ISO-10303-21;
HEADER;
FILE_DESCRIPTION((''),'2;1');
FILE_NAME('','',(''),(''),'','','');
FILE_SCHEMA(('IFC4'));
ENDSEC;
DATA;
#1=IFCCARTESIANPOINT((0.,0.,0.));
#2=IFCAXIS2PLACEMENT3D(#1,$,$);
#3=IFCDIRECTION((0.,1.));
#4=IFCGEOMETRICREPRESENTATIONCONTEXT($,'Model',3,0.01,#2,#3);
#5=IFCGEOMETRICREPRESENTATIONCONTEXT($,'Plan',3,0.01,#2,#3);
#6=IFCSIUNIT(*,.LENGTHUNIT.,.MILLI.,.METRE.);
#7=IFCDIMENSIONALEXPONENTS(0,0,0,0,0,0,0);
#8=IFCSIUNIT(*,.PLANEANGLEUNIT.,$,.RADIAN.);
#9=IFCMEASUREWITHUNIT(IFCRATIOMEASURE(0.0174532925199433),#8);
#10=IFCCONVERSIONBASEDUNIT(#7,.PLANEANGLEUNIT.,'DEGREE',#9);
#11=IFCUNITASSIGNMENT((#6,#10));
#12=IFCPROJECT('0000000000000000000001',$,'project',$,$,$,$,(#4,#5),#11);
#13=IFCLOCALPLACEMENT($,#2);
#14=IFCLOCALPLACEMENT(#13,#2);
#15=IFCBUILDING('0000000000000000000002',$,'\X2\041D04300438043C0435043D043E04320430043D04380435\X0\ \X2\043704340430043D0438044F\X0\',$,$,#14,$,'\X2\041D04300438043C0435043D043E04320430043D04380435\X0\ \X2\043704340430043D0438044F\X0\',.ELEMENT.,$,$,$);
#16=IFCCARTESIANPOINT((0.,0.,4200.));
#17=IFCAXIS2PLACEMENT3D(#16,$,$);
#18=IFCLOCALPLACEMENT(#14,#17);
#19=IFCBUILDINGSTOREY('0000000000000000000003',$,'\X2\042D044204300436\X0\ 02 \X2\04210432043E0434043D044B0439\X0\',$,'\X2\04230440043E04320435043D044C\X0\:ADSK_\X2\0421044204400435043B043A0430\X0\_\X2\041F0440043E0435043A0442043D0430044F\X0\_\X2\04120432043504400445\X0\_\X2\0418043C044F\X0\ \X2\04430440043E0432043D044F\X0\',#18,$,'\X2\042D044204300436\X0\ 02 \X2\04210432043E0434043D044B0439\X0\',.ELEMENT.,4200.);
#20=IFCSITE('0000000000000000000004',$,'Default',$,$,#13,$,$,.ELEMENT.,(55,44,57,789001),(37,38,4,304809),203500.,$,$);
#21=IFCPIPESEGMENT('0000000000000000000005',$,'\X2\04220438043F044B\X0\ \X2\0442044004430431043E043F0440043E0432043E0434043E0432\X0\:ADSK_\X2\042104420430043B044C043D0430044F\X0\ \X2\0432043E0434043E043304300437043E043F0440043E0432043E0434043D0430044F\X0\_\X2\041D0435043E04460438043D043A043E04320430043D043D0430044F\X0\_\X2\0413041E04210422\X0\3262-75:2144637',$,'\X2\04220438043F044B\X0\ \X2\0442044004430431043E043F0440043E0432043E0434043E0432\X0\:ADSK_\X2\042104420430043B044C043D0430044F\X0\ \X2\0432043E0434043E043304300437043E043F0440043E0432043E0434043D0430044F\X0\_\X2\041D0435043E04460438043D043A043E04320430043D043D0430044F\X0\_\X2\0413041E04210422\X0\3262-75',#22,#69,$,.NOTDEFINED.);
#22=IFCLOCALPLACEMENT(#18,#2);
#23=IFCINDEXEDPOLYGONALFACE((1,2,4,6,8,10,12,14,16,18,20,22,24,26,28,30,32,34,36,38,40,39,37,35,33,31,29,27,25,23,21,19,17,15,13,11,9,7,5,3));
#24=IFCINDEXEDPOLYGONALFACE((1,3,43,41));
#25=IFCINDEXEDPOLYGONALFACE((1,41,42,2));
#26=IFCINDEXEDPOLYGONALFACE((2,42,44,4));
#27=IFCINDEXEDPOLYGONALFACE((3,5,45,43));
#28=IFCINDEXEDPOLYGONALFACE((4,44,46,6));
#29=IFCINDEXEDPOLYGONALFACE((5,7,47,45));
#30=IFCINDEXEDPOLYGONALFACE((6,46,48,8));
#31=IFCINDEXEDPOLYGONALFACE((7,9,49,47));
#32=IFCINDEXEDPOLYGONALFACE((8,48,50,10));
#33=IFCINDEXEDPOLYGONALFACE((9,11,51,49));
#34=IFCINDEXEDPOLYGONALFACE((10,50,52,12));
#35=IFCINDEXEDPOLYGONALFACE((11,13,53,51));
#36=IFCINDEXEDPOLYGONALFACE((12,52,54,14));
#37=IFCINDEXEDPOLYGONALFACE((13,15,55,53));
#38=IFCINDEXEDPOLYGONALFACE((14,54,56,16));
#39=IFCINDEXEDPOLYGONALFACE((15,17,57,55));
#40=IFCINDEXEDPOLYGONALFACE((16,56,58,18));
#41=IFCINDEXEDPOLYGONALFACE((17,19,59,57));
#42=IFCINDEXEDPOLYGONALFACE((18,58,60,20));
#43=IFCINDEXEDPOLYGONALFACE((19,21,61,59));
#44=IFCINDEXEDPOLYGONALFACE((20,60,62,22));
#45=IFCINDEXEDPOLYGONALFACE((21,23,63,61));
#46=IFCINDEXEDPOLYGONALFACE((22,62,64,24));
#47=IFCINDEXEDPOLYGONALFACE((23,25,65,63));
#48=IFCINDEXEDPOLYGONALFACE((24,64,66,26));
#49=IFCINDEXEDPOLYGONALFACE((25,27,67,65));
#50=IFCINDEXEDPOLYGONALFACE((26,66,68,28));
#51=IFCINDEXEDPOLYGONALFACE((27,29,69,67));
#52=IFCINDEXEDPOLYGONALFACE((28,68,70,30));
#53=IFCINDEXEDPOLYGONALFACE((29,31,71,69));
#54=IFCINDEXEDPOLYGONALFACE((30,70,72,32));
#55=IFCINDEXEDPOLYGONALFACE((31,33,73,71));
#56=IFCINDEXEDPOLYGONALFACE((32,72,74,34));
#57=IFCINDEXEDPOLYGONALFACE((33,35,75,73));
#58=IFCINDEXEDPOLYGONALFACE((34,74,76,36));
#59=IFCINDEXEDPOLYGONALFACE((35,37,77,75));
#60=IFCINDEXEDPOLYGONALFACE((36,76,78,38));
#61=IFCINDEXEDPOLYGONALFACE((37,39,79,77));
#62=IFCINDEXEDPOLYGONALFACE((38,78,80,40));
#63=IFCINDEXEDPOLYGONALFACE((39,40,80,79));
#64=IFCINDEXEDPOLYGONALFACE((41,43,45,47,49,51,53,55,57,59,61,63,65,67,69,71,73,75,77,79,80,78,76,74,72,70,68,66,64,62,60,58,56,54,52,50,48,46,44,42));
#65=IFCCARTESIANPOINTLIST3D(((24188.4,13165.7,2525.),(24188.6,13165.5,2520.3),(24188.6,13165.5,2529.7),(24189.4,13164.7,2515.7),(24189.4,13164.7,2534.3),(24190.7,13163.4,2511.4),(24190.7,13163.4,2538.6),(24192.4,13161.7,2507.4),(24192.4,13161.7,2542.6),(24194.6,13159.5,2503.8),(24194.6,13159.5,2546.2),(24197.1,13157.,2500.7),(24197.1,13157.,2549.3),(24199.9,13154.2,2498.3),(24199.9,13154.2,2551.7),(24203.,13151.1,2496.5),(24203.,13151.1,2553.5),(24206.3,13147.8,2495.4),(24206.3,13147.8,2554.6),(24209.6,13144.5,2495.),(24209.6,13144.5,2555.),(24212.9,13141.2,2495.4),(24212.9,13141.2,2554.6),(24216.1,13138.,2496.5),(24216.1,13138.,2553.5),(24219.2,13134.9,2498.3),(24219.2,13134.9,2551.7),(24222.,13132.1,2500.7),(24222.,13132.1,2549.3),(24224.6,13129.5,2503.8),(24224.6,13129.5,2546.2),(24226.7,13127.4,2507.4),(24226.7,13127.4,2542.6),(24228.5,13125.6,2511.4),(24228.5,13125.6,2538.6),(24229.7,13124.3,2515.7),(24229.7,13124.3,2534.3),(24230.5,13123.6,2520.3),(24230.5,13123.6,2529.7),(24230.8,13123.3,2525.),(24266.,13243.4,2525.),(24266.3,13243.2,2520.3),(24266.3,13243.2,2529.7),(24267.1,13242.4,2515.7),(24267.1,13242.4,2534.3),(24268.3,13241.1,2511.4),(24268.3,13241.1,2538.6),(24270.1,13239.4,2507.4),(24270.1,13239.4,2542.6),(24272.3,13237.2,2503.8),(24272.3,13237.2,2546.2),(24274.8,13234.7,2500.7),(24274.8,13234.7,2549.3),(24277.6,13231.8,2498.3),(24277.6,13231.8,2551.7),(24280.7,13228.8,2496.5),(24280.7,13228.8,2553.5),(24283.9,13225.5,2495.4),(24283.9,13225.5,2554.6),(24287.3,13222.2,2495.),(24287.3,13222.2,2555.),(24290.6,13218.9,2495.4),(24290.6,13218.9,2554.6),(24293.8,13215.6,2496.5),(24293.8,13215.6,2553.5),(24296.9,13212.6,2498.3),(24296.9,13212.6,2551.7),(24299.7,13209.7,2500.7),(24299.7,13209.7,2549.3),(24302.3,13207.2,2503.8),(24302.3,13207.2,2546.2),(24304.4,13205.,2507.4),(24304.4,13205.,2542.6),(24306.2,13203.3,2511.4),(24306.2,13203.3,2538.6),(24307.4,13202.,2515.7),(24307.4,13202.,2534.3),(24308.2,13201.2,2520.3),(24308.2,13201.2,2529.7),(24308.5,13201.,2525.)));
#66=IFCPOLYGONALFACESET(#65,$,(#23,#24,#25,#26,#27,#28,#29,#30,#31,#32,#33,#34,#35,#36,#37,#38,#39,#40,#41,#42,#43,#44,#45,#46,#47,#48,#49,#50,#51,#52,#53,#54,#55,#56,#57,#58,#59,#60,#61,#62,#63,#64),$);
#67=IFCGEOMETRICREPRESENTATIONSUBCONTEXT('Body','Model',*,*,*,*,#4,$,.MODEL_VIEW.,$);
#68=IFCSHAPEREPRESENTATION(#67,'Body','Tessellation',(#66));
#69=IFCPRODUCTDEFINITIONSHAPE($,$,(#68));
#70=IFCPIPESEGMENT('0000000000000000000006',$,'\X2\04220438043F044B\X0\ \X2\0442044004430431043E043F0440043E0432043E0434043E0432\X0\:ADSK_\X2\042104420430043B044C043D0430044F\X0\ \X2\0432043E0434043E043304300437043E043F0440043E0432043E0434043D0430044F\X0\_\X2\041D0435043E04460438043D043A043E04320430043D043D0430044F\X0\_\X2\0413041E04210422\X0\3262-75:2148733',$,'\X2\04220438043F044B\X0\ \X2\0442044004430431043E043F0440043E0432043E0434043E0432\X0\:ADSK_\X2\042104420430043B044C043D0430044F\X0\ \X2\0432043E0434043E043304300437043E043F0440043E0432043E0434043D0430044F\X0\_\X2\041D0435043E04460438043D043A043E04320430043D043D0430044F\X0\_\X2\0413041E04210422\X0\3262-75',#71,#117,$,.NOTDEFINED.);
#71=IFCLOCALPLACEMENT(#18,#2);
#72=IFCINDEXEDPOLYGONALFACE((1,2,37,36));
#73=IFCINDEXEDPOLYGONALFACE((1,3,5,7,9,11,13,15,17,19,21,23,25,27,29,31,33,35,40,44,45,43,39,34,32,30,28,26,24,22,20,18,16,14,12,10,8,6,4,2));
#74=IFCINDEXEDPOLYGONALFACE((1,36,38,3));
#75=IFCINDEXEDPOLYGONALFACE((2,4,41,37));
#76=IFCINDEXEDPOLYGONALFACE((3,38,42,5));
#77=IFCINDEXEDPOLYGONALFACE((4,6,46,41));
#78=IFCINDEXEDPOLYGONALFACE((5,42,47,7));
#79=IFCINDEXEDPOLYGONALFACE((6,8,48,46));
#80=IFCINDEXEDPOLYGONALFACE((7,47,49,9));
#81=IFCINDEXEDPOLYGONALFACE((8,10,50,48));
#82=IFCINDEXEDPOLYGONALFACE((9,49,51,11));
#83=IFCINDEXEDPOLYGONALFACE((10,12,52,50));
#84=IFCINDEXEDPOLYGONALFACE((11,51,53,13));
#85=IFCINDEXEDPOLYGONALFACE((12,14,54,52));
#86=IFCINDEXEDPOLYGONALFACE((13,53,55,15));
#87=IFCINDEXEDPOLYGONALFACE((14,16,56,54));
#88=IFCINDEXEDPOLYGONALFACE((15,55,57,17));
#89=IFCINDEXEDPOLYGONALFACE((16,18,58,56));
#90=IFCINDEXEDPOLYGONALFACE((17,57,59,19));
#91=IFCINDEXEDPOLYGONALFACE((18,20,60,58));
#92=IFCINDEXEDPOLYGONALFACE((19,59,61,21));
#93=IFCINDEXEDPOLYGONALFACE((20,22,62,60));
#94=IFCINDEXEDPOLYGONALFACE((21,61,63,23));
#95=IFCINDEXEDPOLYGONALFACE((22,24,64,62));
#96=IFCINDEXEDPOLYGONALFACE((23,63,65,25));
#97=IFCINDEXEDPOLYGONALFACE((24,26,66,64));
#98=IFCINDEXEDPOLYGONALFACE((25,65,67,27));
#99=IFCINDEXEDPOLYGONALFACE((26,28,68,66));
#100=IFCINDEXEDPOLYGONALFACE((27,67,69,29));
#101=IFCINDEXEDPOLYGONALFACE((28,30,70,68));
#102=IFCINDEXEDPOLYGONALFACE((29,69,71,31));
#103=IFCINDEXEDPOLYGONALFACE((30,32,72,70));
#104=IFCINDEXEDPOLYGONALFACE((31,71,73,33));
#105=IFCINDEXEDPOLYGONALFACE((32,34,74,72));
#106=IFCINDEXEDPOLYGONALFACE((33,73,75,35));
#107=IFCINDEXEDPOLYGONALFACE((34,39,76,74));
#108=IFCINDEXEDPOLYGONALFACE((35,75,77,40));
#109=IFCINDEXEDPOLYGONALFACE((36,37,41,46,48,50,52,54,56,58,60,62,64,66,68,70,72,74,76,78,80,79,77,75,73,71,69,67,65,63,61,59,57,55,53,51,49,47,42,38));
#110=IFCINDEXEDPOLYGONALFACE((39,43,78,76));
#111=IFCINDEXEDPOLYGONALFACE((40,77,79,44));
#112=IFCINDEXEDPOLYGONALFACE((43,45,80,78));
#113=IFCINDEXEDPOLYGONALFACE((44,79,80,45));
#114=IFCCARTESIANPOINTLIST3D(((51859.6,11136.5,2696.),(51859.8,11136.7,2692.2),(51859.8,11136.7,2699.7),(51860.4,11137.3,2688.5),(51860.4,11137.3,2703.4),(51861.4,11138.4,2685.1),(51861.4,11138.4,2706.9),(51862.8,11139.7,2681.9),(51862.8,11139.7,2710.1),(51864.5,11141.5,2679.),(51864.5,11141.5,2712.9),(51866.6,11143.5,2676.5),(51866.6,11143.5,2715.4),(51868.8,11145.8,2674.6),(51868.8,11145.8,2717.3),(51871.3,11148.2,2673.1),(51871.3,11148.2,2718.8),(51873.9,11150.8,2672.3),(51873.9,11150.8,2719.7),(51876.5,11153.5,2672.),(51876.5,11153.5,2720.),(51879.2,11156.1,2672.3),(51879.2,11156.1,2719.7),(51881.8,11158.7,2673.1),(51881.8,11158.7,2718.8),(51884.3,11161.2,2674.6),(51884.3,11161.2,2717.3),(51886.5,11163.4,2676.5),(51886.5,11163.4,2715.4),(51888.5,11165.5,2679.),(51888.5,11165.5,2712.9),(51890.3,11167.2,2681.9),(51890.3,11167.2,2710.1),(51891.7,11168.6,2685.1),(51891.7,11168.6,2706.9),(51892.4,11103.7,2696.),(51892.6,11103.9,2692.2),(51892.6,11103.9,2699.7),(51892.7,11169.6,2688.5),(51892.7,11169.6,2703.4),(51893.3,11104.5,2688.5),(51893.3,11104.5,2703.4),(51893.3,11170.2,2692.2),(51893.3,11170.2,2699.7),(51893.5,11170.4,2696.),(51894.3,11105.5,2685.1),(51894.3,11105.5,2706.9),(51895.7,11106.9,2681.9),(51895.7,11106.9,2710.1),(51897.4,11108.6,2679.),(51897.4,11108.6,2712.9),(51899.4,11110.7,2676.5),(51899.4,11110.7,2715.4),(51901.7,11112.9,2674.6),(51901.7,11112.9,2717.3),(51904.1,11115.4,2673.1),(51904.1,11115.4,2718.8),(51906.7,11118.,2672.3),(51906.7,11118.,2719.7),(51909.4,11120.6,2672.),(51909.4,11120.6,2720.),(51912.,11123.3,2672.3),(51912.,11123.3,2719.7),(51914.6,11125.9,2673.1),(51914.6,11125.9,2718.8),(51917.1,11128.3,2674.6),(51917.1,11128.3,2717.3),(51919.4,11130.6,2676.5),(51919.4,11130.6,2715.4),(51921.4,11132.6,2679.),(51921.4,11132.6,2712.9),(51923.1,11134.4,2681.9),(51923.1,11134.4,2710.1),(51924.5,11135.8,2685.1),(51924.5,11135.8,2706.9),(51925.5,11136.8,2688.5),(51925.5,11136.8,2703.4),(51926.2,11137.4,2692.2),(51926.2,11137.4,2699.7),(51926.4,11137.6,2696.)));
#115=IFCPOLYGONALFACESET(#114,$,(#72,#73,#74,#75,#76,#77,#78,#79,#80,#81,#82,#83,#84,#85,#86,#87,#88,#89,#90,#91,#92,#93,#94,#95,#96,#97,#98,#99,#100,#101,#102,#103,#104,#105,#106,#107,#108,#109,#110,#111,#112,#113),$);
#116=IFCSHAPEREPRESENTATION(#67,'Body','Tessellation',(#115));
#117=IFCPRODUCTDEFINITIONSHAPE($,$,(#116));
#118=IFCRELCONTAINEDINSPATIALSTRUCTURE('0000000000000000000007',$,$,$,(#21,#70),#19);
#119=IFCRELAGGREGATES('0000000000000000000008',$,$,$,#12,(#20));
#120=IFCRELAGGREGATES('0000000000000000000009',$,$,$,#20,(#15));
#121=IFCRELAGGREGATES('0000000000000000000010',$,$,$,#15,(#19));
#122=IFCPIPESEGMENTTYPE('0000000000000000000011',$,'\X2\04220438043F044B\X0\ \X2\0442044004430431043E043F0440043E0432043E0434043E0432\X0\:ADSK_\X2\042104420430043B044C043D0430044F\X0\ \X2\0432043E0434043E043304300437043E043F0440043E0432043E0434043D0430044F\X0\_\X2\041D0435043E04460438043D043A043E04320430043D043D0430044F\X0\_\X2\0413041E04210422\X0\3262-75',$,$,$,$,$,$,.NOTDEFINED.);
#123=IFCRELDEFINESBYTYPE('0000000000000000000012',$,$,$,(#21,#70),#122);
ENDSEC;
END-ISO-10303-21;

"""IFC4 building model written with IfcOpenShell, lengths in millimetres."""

from ifc_helpers import new_model, entity, si_unit, converted_unit, direction, frame, origin, place, context, subcontext, project, spatial, indexed_curve, outline, extrude, type_object, element, save


model = new_model("IFC4")

# Units and contexts
model_context = context("Model", 3, precision=0.01, world=origin(), true_north=direction((0.0, 1.0)))
plan_context = context("Plan", 3, precision=0.01, world=origin(), true_north=direction((0.0, 1.0)))
body_context = subcontext(model_context, "Body", "Model", "MODEL_VIEW")
ifc_project = project(units=[si_unit("LENGTHUNIT", "METRE", prefix="MILLI"), converted_unit("PLANEANGLEUNIT", "DEGREE", entity("IfcRatioMeasure", 0.0174532925199433), si_unit("PLANEANGLEUNIT", "RADIAN"), dimensions=[0, 0, 0, 0, 0, 0, 0])], contexts=[model_context, plan_context])

# Site, building, storey
site_placement = place(None, origin())
site = spatial("IfcSite", under=ifc_project, at=site_placement, Name="Default", CompositionType="ELEMENT", RefLatitude=(55, 44, 57, 789001), RefLongitude=(37, 38, 4, 304809), RefElevation=203500.0)
building_placement = place(site_placement, origin())
building = spatial("IfcBuilding", under=site, at=building_placement, Name="Наименование здания", LongName="Наименование здания", CompositionType="ELEMENT")
storey_placement = place(building_placement, frame((0.0, 0.0, 4200.0)))
storey = spatial("IfcBuildingStorey", under=building, at=storey_placement, Name="Этаж 02 Сводный", ObjectType="Уровень:ADSK_Стрелка_Проектная_Вверх_Имя уровня", LongName="Этаж 02 Сводный", CompositionType="ELEMENT", Elevation=4200.0)

# Pipe segments
placement = place(storey_placement, origin())
pipe_segment_type_1 = type_object("IfcPipeSegmentType", Name="Типы трубопроводов:ADSK_Стальная водогазопроводная_Неоцинкованная_ГОСТ3262-75", PredefinedType="NOTDEFINED")
element("IfcPipeSegment", 1, at=placement, inside=storey, type_object=pipe_segment_type_1, Name="Типы трубопроводов:ADSK_Стальная водогазопроводная_Неоцинкованная_ГОСТ3262-75:2144637", ObjectType="Типы трубопроводов:ADSK_Стальная водогазопроводная_Неоцинкованная_ГОСТ3262-75", PredefinedType="NOTDEFINED", context=body_context, shape_type="SweptSolid", body=[
    extrude(outline(indexed_curve([(30.0, 0.0), (29.6, 4.7), (28.5, 9.3), (26.7, 13.6), (24.3, 17.6), (21.2, 21.2), (17.6, 24.3), (13.6, 26.7), (9.3, 28.5), (4.7, 29.6), (0.0, 30.0), (-4.7, 29.6), (-9.3, 28.5), (-13.6, 26.7), (-17.6, 24.3), (-21.2, 21.2), (-24.3, 17.6), (-26.7, 13.6), (-28.5, 9.3), (-29.6, 4.7), (-30.0, 0.0), (-29.6, -4.7), (-28.5, -9.3), (-26.7, -13.6), (-24.3, -17.6), (-21.2, -21.2), (-17.6, -24.3), (-13.6, -26.7), (-9.3, -28.5), (-4.7, -29.6), (0.0, -30.0), (4.7, -29.6), (9.3, -28.5), (13.6, -26.7), (17.6, -24.3), (21.2, -21.2), (24.3, -17.6), (26.7, -13.6), (28.5, -9.3), (29.6, -4.7), (30.0, 0.0)], self_intersect=False)), frame((24209.6, 13144.5, 2525.0), z_axis=(0.707107, 0.707107, 0.0), x_axis=(0.707107, -0.707107, 0.0)), (0.0, 0.0, 1.0), 109.9),
])
element("IfcPipeSegment", 2, at=placement, inside=storey, type_object=pipe_segment_type_1, Name="Типы трубопроводов:ADSK_Стальная водогазопроводная_Неоцинкованная_ГОСТ3262-75:2148733", ObjectType="Типы трубопроводов:ADSK_Стальная водогазопроводная_Неоцинкованная_ГОСТ3262-75", PredefinedType="NOTDEFINED", context=body_context, shape_type="SweptSolid", body=[
    extrude(outline(indexed_curve([(24.0, 0.0), (23.7, 3.8), (22.8, 7.4), (21.4, 10.9), (19.4, 14.1), (17.0, 17.0), (14.1, 19.4), (10.9, 21.4), (7.4, 22.8), (3.8, 23.7), (0.0, 24.0), (-3.8, 23.7), (-7.4, 22.8), (-10.9, 21.4), (-14.1, 19.4), (-17.0, 17.0), (-19.4, 14.1), (-21.4, 10.9), (-22.8, 7.4), (-23.7, 3.8), (-24.0, 0.0), (-23.7, -3.8), (-22.8, -7.4), (-21.4, -10.9), (-19.4, -14.1), (-17.0, -17.0), (-14.1, -19.4), (-10.9, -21.4), (-7.4, -22.8), (-3.8, -23.7), (0.0, -24.0), (3.8, -23.7), (7.4, -22.8), (10.9, -21.4), (14.1, -19.4), (17.0, -17.0), (19.4, -14.1), (21.4, -10.9), (22.8, -7.4), (23.7, -3.8), (24.0, 0.0)], self_intersect=False)), frame((51909.4, 11120.6, 2696.0), z_axis=(-0.707107, 0.707107, 0.0), x_axis=(-0.707107, -0.707107, 0.0)), (0.0, 0.0, 1.0), 46.4),
])

save(model, "model.ifc")
